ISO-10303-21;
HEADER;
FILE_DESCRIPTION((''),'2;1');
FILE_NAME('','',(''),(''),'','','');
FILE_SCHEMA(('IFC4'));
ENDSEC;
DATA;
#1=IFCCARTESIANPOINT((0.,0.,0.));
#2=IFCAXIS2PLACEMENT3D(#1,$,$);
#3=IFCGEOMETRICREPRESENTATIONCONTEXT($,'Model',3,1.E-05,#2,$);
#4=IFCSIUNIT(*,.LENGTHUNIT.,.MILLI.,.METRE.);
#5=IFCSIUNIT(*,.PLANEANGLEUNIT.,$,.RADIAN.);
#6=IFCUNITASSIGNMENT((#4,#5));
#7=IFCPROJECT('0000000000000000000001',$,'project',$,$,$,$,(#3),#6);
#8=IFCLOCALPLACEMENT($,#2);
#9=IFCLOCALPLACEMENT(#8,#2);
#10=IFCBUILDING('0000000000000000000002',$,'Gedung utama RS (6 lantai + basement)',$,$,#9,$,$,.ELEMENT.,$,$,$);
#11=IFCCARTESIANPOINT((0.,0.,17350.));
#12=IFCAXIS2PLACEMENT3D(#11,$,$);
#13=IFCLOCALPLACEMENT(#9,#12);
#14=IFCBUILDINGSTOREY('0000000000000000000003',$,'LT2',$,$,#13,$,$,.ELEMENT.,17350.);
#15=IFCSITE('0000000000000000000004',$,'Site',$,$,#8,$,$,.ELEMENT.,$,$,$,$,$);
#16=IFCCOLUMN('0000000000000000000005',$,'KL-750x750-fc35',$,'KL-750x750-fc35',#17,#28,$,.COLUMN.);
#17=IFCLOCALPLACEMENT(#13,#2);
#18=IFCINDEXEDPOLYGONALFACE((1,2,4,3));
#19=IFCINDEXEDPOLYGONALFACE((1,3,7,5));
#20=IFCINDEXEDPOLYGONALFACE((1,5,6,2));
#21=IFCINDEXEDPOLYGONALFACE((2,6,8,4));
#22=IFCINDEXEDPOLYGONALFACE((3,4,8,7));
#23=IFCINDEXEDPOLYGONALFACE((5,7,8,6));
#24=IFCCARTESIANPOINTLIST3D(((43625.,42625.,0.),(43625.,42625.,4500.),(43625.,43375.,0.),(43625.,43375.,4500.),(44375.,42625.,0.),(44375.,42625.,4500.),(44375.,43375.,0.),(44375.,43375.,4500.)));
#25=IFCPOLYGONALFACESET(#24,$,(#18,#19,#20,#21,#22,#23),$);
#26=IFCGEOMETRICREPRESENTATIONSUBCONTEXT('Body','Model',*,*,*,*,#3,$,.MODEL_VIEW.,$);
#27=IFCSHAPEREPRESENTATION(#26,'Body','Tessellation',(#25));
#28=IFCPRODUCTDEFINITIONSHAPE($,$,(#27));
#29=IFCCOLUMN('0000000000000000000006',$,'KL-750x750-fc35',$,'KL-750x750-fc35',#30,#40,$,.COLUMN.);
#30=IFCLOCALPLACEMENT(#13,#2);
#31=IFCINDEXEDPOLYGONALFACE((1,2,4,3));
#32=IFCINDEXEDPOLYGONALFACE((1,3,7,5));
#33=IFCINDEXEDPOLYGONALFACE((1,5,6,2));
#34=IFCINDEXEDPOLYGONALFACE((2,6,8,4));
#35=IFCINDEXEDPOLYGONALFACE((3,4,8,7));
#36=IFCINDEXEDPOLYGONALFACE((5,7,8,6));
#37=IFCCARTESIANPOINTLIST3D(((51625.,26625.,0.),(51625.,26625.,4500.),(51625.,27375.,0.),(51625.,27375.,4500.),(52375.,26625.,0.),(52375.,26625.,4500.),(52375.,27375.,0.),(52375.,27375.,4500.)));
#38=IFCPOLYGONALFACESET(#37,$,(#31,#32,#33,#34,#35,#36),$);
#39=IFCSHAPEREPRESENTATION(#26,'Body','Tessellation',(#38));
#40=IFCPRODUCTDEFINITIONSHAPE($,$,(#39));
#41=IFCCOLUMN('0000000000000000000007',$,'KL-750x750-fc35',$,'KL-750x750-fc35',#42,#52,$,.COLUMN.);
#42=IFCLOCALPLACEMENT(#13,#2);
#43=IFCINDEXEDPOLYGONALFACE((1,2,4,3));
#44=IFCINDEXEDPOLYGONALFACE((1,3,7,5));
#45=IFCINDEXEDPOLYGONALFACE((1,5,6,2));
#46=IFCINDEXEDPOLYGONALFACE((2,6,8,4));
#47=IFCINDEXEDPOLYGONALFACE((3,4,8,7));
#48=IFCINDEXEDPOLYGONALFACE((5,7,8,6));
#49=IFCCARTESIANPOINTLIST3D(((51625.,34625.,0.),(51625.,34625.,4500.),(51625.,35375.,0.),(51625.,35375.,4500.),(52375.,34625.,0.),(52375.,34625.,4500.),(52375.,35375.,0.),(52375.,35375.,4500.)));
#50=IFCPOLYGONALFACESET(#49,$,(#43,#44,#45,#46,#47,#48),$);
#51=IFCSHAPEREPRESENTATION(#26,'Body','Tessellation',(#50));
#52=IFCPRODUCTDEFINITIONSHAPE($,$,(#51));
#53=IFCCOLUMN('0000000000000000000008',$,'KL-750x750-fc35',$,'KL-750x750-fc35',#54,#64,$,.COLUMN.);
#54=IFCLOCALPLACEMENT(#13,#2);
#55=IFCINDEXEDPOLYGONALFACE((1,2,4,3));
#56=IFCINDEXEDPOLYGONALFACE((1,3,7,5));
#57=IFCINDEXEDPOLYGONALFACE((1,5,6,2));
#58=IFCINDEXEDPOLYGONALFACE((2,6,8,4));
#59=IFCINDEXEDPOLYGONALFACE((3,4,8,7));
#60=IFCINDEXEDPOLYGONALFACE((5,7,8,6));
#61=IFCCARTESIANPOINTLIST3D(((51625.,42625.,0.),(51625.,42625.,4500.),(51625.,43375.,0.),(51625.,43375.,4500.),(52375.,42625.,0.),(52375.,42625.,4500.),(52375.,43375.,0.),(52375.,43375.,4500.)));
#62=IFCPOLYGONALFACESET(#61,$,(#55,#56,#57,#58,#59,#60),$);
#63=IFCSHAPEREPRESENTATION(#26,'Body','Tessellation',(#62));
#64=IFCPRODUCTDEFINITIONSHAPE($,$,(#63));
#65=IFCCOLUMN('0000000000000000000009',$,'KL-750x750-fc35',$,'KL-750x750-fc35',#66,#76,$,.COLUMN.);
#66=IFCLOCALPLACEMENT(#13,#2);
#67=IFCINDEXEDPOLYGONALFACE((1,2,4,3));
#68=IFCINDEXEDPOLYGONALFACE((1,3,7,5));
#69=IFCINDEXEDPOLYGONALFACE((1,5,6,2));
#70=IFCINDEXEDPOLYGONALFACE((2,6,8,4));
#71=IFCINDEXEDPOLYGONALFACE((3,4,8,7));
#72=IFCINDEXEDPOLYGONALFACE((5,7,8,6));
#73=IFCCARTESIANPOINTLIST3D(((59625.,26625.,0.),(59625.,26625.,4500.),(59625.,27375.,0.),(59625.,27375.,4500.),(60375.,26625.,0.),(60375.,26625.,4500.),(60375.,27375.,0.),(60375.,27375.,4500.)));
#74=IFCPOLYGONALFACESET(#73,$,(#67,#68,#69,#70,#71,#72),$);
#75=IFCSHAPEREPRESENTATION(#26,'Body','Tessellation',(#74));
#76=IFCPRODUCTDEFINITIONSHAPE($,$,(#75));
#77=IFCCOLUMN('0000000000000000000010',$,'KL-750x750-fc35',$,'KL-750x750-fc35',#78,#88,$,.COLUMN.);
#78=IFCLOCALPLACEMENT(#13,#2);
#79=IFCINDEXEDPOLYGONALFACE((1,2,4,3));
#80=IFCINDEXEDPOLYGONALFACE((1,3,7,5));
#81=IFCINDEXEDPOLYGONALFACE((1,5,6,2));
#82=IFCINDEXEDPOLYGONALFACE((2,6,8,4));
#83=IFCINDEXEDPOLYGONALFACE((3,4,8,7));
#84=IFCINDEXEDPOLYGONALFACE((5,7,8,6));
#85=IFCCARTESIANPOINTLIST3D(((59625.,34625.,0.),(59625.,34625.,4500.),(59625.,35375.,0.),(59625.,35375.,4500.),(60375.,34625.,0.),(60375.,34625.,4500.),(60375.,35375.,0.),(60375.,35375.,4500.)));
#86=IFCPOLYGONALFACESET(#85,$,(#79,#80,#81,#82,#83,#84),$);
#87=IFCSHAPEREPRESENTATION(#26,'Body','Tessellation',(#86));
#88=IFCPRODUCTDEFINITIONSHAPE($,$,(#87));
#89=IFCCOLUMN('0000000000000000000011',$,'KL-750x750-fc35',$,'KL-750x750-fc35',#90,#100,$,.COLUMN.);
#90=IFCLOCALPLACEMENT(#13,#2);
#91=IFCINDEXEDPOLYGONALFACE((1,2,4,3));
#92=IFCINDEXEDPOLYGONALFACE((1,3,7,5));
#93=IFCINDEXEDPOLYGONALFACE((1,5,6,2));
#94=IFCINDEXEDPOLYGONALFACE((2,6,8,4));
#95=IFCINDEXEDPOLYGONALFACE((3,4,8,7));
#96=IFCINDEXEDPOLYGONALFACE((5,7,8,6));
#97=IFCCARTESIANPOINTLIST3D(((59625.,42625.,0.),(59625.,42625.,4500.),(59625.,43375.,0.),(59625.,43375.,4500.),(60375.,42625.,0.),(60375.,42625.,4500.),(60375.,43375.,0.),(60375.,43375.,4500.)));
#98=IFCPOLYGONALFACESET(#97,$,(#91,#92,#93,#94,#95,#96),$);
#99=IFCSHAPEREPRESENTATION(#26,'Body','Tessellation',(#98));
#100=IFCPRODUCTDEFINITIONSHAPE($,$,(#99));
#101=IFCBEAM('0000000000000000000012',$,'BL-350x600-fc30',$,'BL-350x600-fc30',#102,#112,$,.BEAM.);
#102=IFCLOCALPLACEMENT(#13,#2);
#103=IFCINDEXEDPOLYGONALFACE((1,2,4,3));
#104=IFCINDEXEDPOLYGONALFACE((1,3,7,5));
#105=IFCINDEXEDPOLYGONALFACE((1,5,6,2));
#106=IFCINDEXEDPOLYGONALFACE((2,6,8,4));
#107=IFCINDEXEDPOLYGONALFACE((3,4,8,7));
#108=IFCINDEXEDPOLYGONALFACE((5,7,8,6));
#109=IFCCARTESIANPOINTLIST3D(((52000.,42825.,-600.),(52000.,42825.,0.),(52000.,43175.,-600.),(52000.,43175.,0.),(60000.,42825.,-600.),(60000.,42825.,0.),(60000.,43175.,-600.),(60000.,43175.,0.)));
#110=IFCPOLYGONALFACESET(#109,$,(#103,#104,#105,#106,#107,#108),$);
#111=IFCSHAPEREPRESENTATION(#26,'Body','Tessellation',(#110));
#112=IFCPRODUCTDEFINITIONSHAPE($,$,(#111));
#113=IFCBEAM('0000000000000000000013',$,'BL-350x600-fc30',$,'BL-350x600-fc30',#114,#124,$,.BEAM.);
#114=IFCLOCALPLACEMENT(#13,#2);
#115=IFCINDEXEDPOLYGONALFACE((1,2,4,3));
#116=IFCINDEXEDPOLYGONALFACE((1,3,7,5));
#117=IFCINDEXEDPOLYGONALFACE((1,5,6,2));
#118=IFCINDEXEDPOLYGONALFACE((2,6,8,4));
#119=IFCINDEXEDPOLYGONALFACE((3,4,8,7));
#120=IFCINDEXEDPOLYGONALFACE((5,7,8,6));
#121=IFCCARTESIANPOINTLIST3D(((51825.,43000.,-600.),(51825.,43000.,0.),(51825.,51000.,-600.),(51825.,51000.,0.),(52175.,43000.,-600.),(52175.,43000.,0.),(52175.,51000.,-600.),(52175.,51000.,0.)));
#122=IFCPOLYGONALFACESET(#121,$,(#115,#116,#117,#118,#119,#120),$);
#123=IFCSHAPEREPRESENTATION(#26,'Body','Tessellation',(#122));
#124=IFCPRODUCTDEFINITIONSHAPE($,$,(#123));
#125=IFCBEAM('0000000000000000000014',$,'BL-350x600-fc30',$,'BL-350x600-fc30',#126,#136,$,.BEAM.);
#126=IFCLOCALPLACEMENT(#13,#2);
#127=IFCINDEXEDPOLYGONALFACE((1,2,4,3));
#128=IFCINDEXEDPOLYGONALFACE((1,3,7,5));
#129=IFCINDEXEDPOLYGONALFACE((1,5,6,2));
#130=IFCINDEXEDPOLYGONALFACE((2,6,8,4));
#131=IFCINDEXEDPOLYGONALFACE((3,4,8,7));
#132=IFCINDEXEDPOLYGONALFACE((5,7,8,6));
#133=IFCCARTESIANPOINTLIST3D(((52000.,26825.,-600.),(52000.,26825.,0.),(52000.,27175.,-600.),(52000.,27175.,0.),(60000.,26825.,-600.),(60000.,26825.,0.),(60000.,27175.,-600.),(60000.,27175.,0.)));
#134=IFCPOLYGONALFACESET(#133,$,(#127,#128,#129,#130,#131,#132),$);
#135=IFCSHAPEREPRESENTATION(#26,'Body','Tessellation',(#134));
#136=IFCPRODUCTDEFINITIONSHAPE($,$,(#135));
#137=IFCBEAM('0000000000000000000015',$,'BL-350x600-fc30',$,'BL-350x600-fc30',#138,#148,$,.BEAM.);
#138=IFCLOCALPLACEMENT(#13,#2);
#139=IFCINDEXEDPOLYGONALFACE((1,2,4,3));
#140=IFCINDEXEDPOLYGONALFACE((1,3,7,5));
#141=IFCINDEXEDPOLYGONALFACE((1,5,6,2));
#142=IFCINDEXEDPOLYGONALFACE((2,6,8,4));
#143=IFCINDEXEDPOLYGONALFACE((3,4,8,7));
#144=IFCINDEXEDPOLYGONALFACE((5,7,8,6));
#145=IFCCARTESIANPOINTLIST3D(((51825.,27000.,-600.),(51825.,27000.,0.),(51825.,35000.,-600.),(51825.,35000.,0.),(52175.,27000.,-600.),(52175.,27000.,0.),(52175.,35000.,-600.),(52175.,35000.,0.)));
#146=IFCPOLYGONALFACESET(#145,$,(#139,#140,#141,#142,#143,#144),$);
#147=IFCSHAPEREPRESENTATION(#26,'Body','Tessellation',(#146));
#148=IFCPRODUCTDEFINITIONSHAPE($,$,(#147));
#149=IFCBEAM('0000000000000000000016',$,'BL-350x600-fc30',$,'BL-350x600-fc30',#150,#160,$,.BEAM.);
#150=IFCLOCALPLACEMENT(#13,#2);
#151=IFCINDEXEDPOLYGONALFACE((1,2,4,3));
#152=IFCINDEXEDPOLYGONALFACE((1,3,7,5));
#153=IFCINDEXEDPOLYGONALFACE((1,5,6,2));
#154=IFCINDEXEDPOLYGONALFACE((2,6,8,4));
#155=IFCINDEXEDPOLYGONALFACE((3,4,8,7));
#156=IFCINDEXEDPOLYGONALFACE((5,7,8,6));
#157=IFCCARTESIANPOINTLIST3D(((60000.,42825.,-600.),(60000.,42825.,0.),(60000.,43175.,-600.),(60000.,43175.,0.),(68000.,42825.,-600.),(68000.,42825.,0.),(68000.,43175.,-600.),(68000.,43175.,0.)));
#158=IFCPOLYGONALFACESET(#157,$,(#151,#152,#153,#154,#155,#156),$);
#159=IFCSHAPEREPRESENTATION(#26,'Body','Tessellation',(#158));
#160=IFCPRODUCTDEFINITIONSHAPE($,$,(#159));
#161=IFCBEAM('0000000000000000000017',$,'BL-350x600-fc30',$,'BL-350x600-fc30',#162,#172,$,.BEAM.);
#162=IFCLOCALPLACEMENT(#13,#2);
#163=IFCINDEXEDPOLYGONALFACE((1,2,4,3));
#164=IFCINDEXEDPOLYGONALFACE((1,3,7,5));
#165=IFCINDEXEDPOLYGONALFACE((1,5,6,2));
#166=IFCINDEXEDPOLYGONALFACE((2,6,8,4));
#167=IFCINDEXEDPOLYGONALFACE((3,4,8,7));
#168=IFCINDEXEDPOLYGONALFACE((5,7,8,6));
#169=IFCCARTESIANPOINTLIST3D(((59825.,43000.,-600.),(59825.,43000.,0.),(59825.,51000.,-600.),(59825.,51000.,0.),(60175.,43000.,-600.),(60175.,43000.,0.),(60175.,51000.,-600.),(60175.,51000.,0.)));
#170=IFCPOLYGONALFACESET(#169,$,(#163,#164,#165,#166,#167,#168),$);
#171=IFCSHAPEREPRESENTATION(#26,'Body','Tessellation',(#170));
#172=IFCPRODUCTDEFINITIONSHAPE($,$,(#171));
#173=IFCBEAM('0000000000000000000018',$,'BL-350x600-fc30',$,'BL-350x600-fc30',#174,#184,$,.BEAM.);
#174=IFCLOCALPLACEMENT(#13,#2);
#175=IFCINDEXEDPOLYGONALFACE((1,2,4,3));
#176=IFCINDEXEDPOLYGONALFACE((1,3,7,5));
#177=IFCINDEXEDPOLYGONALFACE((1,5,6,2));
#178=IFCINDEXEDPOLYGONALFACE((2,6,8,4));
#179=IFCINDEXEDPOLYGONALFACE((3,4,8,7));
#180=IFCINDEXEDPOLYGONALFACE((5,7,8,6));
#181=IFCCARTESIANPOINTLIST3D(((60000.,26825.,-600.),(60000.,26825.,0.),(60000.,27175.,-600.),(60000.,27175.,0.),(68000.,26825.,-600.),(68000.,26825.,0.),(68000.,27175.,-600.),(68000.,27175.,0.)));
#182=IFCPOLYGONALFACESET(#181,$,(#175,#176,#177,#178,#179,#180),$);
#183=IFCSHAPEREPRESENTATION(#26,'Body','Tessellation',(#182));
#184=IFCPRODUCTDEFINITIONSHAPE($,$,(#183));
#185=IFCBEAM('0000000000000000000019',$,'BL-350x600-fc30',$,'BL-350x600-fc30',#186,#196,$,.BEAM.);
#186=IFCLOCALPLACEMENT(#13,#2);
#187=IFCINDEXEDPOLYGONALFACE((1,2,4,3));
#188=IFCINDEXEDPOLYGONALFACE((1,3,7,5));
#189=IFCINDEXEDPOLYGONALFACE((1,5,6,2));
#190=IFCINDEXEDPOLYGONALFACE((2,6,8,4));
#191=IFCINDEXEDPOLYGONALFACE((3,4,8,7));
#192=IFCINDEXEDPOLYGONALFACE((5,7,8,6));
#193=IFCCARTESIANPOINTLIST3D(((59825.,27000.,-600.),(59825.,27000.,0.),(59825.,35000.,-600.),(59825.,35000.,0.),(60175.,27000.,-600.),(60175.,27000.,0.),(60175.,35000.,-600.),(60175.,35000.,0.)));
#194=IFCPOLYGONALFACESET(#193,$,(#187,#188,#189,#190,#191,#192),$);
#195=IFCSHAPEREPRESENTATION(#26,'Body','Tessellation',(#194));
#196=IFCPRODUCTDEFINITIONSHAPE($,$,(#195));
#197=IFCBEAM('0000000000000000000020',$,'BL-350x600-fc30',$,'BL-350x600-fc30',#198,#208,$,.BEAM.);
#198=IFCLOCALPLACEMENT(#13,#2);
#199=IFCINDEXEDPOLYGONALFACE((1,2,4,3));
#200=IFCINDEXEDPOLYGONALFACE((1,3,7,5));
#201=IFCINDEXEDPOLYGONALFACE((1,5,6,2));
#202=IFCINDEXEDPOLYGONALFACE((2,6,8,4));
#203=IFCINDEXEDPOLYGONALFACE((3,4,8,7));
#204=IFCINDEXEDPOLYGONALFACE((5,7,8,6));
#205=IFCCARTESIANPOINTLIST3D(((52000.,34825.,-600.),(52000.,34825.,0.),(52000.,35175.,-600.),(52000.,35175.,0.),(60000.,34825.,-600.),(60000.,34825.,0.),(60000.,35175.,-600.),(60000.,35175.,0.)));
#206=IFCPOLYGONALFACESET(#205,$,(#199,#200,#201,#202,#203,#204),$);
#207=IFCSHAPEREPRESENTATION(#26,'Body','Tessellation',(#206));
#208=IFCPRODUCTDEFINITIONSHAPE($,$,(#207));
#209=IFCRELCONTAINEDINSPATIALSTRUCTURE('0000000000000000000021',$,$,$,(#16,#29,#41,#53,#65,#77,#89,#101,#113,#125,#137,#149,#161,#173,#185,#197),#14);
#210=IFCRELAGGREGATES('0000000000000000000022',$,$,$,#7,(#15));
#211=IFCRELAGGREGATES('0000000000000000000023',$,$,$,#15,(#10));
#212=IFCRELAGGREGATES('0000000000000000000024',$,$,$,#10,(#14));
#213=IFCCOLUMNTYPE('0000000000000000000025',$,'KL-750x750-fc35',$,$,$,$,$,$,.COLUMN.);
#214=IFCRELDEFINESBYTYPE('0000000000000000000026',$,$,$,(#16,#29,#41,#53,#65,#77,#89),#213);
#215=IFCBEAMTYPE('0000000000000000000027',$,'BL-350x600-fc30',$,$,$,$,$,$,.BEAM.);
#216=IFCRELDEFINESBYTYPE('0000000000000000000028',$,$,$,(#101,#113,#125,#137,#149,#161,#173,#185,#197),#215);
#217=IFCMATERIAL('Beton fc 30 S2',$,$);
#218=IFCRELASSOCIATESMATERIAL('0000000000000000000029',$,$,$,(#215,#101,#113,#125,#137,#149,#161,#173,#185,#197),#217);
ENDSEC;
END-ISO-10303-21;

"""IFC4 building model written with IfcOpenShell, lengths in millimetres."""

from ifc_helpers import new_model, si_unit, frame, origin, origin_2d, place, context, subcontext, project, spatial, rectangle, extrude, material, material_profile, profile_set, profile_usage, type_object, element, save


model = new_model("IFC4")

# Units and contexts
model_context = context("Model", 3, precision=1e-05, world=origin())
body_context = subcontext(model_context, "Body", "Model", "MODEL_VIEW")
ifc_project = project(units=[si_unit("LENGTHUNIT", "METRE", prefix="MILLI"), si_unit("PLANEANGLEUNIT", "RADIAN")], contexts=[model_context])

# Site, building, storey
site_placement = place(None, origin())
site = spatial("IfcSite", under=ifc_project, at=site_placement, Name="Site", CompositionType="ELEMENT")
building_placement = place(site_placement, origin())
building = spatial("IfcBuilding", under=site, at=building_placement, Name="Gedung utama RS (6 lantai + basement)", CompositionType="ELEMENT")
storey_placement = place(building_placement, frame((0.0, 0.0, 17350.0)))
storey = spatial("IfcBuildingStorey", under=building, at=storey_placement, Name="LT2", CompositionType="ELEMENT", Elevation=17350.0)

# Columns
ifc_material_profile_1 = material_profile(None, rectangle(XDim=750.0, YDim=750.0, at=origin_2d()), Name="KL-750x750-fc35")
ifc_profile_set_1 = profile_set([ifc_material_profile_1], Name="KL-750x750-fc35")
ifc_profile_usage_1 = profile_usage(ifc_profile_set_1, cardinal=5)
column_type = type_object("IfcColumnType", Name="KL-750x750-fc35", PredefinedType="COLUMN", material=ifc_profile_set_1)
for number, where, z_axis, x_axis, name in (
    (1, (44000.0, 43000.0, 0.0), (0.0, 0.0, 1.0), (1.0, 0.0, 0.0), "KL-750x750-fc35"),
    (2, (52000.0, 27000.0, 0.0), (0.0, 0.0, 1.0), (1.0, 0.0, 0.0), "KL-750x750-fc35"),
    (3, (52000.0, 35000.0, 0.0), (0.0, 0.0, 1.0), (1.0, 0.0, 0.0), "KL-750x750-fc35"),
    (4, (52000.0, 43000.0, 0.0), (0.0, 0.0, 1.0), (1.0, 0.0, 0.0), "KL-750x750-fc35"),
    (5, (60000.0, 27000.0, 0.0), (0.0, 0.0, 1.0), (1.0, 0.0, 0.0), "KL-750x750-fc35"),
    (6, (60000.0, 35000.0, 0.0), (0.0, 0.0, 1.0), (1.0, 0.0, 0.0), "KL-750x750-fc35"),
    (7, (60000.0, 43000.0, 0.0), (0.0, 0.0, 1.0), (1.0, 0.0, 0.0), "KL-750x750-fc35"),
):
    element("IfcColumn", number, at=place(storey_placement, frame(where, z_axis=z_axis, x_axis=x_axis)), inside=storey, type_object=column_type, material=ifc_profile_usage_1, Name=name, ObjectType="KL-750x750-fc35", PredefinedType="COLUMN", context=body_context, shape_type="SweptSolid", body=[
        extrude(rectangle(XDim=750.0, YDim=750.0, at=origin_2d()), origin(), (0.0, 0.0, 1.0), 4500.0),
    ])

# Beams
ifc_material_1 = material(Name="Beton fc 30 S2")
ifc_material_profile_2 = material_profile(ifc_material_1, rectangle(XDim=350.0, YDim=600.0, at=origin_2d()), Name="BL-350x600-fc30")
ifc_profile_set_2 = profile_set([ifc_material_profile_2], Name="BL-350x600-fc30")
ifc_profile_usage_2 = profile_usage(ifc_profile_set_2, cardinal=8)
beam_type = type_object("IfcBeamType", Name="BL-350x600-fc30", PredefinedType="BEAM", material=ifc_profile_set_2)
beam_1_placement = place(storey_placement, frame((52000.0, 43000.0, -300.0)))
element("IfcBeam", 8, at=beam_1_placement, inside=storey, type_object=beam_type, material=ifc_profile_usage_2, Name="BL-350x600-fc30", ObjectType="BL-350x600-fc30", PredefinedType="BEAM", context=body_context, shape_type="SweptSolid", body=[
    extrude(rectangle(XDim=350.0, YDim=600.0, at=origin_2d()), frame((0.0, 0.0, 0.0), z_axis=(1.0, 0.0, 0.0), x_axis=(0.0, 1.0, 0.0)), (0.0, 0.0, 1.0), 8000.0),
])
beam_2_placement = place(storey_placement, frame((52000.0, 43000.0, -300.0)))
element("IfcBeam", 9, at=beam_2_placement, inside=storey, type_object=beam_type, material=ifc_profile_usage_2, Name="BL-350x600-fc30", ObjectType="BL-350x600-fc30", PredefinedType="BEAM", context=body_context, shape_type="SweptSolid", body=[
    extrude(rectangle(XDim=350.0, YDim=600.0, at=origin_2d()), frame((0.0, 0.0, 0.0), z_axis=(0.0, 1.0, 0.0), x_axis=(-1.0, 0.0, 0.0)), (0.0, 0.0, 1.0), 8000.0),
])
beam_3_placement = place(storey_placement, frame((52000.0, 27000.0, -300.0)))
element("IfcBeam", 10, at=beam_3_placement, inside=storey, type_object=beam_type, material=ifc_profile_usage_2, Name="BL-350x600-fc30", ObjectType="BL-350x600-fc30", PredefinedType="BEAM", context=body_context, shape_type="SweptSolid", body=[
    extrude(rectangle(XDim=350.0, YDim=600.0, at=origin_2d()), frame((0.0, 0.0, 0.0), z_axis=(1.0, 0.0, 0.0), x_axis=(0.0, 1.0, 0.0)), (0.0, 0.0, 1.0), 8000.0),
])
beam_4_placement = place(storey_placement, frame((52000.0, 27000.0, -300.0)))
element("IfcBeam", 11, at=beam_4_placement, inside=storey, type_object=beam_type, material=ifc_profile_usage_2, Name="BL-350x600-fc30", ObjectType="BL-350x600-fc30", PredefinedType="BEAM", context=body_context, shape_type="SweptSolid", body=[
    extrude(rectangle(XDim=350.0, YDim=600.0, at=origin_2d()), frame((0.0, 0.0, 0.0), z_axis=(0.0, 1.0, 0.0), x_axis=(-1.0, 0.0, 0.0)), (0.0, 0.0, 1.0), 8000.0),
])
beam_5_placement = place(storey_placement, frame((60000.0, 43000.0, -300.0)))
element("IfcBeam", 12, at=beam_5_placement, inside=storey, type_object=beam_type, material=ifc_profile_usage_2, Name="BL-350x600-fc30", ObjectType="BL-350x600-fc30", PredefinedType="BEAM", context=body_context, shape_type="SweptSolid", body=[
    extrude(rectangle(XDim=350.0, YDim=600.0, at=origin_2d()), frame((0.0, 0.0, 0.0), z_axis=(1.0, 0.0, 0.0), x_axis=(0.0, 1.0, 0.0)), (0.0, 0.0, 1.0), 8000.0),
])
beam_6_placement = place(storey_placement, frame((60000.0, 43000.0, -300.0)))
element("IfcBeam", 13, at=beam_6_placement, inside=storey, type_object=beam_type, material=ifc_profile_usage_2, Name="BL-350x600-fc30", ObjectType="BL-350x600-fc30", PredefinedType="BEAM", context=body_context, shape_type="SweptSolid", body=[
    extrude(rectangle(XDim=350.0, YDim=600.0, at=origin_2d()), frame((0.0, 0.0, 0.0), z_axis=(0.0, 1.0, 0.0), x_axis=(-1.0, 0.0, 0.0)), (0.0, 0.0, 1.0), 8000.0),
])
beam_7_placement = place(storey_placement, frame((60000.0, 27000.0, -300.0)))
element("IfcBeam", 14, at=beam_7_placement, inside=storey, type_object=beam_type, material=ifc_profile_usage_2, Name="BL-350x600-fc30", ObjectType="BL-350x600-fc30", PredefinedType="BEAM", context=body_context, shape_type="SweptSolid", body=[
    extrude(rectangle(XDim=350.0, YDim=600.0, at=origin_2d()), frame((0.0, 0.0, 0.0), z_axis=(1.0, 0.0, 0.0), x_axis=(0.0, 1.0, 0.0)), (0.0, 0.0, 1.0), 8000.0),
])
beam_8_placement = place(storey_placement, frame((60000.0, 27000.0, -300.0)))
element("IfcBeam", 15, at=beam_8_placement, inside=storey, type_object=beam_type, material=ifc_profile_usage_2, Name="BL-350x600-fc30", ObjectType="BL-350x600-fc30", PredefinedType="BEAM", context=body_context, shape_type="SweptSolid", body=[
    extrude(rectangle(XDim=350.0, YDim=600.0, at=origin_2d()), frame((0.0, 0.0, 0.0), z_axis=(0.0, 1.0, 0.0), x_axis=(-1.0, 0.0, 0.0)), (0.0, 0.0, 1.0), 8000.0),
])
beam_9_placement = place(storey_placement, frame((52000.0, 35000.0, -300.0)))
element("IfcBeam", 16, at=beam_9_placement, inside=storey, type_object=beam_type, material=ifc_profile_usage_2, Name="BL-350x600-fc30", ObjectType="BL-350x600-fc30", PredefinedType="BEAM", context=body_context, shape_type="SweptSolid", body=[
    extrude(rectangle(XDim=350.0, YDim=600.0, at=origin_2d()), frame((0.0, 0.0, 0.0), z_axis=(1.0, 0.0, 0.0), x_axis=(0.0, 1.0, 0.0)), (0.0, 0.0, 1.0), 8000.0),
])

save(model, "model.ifc")
